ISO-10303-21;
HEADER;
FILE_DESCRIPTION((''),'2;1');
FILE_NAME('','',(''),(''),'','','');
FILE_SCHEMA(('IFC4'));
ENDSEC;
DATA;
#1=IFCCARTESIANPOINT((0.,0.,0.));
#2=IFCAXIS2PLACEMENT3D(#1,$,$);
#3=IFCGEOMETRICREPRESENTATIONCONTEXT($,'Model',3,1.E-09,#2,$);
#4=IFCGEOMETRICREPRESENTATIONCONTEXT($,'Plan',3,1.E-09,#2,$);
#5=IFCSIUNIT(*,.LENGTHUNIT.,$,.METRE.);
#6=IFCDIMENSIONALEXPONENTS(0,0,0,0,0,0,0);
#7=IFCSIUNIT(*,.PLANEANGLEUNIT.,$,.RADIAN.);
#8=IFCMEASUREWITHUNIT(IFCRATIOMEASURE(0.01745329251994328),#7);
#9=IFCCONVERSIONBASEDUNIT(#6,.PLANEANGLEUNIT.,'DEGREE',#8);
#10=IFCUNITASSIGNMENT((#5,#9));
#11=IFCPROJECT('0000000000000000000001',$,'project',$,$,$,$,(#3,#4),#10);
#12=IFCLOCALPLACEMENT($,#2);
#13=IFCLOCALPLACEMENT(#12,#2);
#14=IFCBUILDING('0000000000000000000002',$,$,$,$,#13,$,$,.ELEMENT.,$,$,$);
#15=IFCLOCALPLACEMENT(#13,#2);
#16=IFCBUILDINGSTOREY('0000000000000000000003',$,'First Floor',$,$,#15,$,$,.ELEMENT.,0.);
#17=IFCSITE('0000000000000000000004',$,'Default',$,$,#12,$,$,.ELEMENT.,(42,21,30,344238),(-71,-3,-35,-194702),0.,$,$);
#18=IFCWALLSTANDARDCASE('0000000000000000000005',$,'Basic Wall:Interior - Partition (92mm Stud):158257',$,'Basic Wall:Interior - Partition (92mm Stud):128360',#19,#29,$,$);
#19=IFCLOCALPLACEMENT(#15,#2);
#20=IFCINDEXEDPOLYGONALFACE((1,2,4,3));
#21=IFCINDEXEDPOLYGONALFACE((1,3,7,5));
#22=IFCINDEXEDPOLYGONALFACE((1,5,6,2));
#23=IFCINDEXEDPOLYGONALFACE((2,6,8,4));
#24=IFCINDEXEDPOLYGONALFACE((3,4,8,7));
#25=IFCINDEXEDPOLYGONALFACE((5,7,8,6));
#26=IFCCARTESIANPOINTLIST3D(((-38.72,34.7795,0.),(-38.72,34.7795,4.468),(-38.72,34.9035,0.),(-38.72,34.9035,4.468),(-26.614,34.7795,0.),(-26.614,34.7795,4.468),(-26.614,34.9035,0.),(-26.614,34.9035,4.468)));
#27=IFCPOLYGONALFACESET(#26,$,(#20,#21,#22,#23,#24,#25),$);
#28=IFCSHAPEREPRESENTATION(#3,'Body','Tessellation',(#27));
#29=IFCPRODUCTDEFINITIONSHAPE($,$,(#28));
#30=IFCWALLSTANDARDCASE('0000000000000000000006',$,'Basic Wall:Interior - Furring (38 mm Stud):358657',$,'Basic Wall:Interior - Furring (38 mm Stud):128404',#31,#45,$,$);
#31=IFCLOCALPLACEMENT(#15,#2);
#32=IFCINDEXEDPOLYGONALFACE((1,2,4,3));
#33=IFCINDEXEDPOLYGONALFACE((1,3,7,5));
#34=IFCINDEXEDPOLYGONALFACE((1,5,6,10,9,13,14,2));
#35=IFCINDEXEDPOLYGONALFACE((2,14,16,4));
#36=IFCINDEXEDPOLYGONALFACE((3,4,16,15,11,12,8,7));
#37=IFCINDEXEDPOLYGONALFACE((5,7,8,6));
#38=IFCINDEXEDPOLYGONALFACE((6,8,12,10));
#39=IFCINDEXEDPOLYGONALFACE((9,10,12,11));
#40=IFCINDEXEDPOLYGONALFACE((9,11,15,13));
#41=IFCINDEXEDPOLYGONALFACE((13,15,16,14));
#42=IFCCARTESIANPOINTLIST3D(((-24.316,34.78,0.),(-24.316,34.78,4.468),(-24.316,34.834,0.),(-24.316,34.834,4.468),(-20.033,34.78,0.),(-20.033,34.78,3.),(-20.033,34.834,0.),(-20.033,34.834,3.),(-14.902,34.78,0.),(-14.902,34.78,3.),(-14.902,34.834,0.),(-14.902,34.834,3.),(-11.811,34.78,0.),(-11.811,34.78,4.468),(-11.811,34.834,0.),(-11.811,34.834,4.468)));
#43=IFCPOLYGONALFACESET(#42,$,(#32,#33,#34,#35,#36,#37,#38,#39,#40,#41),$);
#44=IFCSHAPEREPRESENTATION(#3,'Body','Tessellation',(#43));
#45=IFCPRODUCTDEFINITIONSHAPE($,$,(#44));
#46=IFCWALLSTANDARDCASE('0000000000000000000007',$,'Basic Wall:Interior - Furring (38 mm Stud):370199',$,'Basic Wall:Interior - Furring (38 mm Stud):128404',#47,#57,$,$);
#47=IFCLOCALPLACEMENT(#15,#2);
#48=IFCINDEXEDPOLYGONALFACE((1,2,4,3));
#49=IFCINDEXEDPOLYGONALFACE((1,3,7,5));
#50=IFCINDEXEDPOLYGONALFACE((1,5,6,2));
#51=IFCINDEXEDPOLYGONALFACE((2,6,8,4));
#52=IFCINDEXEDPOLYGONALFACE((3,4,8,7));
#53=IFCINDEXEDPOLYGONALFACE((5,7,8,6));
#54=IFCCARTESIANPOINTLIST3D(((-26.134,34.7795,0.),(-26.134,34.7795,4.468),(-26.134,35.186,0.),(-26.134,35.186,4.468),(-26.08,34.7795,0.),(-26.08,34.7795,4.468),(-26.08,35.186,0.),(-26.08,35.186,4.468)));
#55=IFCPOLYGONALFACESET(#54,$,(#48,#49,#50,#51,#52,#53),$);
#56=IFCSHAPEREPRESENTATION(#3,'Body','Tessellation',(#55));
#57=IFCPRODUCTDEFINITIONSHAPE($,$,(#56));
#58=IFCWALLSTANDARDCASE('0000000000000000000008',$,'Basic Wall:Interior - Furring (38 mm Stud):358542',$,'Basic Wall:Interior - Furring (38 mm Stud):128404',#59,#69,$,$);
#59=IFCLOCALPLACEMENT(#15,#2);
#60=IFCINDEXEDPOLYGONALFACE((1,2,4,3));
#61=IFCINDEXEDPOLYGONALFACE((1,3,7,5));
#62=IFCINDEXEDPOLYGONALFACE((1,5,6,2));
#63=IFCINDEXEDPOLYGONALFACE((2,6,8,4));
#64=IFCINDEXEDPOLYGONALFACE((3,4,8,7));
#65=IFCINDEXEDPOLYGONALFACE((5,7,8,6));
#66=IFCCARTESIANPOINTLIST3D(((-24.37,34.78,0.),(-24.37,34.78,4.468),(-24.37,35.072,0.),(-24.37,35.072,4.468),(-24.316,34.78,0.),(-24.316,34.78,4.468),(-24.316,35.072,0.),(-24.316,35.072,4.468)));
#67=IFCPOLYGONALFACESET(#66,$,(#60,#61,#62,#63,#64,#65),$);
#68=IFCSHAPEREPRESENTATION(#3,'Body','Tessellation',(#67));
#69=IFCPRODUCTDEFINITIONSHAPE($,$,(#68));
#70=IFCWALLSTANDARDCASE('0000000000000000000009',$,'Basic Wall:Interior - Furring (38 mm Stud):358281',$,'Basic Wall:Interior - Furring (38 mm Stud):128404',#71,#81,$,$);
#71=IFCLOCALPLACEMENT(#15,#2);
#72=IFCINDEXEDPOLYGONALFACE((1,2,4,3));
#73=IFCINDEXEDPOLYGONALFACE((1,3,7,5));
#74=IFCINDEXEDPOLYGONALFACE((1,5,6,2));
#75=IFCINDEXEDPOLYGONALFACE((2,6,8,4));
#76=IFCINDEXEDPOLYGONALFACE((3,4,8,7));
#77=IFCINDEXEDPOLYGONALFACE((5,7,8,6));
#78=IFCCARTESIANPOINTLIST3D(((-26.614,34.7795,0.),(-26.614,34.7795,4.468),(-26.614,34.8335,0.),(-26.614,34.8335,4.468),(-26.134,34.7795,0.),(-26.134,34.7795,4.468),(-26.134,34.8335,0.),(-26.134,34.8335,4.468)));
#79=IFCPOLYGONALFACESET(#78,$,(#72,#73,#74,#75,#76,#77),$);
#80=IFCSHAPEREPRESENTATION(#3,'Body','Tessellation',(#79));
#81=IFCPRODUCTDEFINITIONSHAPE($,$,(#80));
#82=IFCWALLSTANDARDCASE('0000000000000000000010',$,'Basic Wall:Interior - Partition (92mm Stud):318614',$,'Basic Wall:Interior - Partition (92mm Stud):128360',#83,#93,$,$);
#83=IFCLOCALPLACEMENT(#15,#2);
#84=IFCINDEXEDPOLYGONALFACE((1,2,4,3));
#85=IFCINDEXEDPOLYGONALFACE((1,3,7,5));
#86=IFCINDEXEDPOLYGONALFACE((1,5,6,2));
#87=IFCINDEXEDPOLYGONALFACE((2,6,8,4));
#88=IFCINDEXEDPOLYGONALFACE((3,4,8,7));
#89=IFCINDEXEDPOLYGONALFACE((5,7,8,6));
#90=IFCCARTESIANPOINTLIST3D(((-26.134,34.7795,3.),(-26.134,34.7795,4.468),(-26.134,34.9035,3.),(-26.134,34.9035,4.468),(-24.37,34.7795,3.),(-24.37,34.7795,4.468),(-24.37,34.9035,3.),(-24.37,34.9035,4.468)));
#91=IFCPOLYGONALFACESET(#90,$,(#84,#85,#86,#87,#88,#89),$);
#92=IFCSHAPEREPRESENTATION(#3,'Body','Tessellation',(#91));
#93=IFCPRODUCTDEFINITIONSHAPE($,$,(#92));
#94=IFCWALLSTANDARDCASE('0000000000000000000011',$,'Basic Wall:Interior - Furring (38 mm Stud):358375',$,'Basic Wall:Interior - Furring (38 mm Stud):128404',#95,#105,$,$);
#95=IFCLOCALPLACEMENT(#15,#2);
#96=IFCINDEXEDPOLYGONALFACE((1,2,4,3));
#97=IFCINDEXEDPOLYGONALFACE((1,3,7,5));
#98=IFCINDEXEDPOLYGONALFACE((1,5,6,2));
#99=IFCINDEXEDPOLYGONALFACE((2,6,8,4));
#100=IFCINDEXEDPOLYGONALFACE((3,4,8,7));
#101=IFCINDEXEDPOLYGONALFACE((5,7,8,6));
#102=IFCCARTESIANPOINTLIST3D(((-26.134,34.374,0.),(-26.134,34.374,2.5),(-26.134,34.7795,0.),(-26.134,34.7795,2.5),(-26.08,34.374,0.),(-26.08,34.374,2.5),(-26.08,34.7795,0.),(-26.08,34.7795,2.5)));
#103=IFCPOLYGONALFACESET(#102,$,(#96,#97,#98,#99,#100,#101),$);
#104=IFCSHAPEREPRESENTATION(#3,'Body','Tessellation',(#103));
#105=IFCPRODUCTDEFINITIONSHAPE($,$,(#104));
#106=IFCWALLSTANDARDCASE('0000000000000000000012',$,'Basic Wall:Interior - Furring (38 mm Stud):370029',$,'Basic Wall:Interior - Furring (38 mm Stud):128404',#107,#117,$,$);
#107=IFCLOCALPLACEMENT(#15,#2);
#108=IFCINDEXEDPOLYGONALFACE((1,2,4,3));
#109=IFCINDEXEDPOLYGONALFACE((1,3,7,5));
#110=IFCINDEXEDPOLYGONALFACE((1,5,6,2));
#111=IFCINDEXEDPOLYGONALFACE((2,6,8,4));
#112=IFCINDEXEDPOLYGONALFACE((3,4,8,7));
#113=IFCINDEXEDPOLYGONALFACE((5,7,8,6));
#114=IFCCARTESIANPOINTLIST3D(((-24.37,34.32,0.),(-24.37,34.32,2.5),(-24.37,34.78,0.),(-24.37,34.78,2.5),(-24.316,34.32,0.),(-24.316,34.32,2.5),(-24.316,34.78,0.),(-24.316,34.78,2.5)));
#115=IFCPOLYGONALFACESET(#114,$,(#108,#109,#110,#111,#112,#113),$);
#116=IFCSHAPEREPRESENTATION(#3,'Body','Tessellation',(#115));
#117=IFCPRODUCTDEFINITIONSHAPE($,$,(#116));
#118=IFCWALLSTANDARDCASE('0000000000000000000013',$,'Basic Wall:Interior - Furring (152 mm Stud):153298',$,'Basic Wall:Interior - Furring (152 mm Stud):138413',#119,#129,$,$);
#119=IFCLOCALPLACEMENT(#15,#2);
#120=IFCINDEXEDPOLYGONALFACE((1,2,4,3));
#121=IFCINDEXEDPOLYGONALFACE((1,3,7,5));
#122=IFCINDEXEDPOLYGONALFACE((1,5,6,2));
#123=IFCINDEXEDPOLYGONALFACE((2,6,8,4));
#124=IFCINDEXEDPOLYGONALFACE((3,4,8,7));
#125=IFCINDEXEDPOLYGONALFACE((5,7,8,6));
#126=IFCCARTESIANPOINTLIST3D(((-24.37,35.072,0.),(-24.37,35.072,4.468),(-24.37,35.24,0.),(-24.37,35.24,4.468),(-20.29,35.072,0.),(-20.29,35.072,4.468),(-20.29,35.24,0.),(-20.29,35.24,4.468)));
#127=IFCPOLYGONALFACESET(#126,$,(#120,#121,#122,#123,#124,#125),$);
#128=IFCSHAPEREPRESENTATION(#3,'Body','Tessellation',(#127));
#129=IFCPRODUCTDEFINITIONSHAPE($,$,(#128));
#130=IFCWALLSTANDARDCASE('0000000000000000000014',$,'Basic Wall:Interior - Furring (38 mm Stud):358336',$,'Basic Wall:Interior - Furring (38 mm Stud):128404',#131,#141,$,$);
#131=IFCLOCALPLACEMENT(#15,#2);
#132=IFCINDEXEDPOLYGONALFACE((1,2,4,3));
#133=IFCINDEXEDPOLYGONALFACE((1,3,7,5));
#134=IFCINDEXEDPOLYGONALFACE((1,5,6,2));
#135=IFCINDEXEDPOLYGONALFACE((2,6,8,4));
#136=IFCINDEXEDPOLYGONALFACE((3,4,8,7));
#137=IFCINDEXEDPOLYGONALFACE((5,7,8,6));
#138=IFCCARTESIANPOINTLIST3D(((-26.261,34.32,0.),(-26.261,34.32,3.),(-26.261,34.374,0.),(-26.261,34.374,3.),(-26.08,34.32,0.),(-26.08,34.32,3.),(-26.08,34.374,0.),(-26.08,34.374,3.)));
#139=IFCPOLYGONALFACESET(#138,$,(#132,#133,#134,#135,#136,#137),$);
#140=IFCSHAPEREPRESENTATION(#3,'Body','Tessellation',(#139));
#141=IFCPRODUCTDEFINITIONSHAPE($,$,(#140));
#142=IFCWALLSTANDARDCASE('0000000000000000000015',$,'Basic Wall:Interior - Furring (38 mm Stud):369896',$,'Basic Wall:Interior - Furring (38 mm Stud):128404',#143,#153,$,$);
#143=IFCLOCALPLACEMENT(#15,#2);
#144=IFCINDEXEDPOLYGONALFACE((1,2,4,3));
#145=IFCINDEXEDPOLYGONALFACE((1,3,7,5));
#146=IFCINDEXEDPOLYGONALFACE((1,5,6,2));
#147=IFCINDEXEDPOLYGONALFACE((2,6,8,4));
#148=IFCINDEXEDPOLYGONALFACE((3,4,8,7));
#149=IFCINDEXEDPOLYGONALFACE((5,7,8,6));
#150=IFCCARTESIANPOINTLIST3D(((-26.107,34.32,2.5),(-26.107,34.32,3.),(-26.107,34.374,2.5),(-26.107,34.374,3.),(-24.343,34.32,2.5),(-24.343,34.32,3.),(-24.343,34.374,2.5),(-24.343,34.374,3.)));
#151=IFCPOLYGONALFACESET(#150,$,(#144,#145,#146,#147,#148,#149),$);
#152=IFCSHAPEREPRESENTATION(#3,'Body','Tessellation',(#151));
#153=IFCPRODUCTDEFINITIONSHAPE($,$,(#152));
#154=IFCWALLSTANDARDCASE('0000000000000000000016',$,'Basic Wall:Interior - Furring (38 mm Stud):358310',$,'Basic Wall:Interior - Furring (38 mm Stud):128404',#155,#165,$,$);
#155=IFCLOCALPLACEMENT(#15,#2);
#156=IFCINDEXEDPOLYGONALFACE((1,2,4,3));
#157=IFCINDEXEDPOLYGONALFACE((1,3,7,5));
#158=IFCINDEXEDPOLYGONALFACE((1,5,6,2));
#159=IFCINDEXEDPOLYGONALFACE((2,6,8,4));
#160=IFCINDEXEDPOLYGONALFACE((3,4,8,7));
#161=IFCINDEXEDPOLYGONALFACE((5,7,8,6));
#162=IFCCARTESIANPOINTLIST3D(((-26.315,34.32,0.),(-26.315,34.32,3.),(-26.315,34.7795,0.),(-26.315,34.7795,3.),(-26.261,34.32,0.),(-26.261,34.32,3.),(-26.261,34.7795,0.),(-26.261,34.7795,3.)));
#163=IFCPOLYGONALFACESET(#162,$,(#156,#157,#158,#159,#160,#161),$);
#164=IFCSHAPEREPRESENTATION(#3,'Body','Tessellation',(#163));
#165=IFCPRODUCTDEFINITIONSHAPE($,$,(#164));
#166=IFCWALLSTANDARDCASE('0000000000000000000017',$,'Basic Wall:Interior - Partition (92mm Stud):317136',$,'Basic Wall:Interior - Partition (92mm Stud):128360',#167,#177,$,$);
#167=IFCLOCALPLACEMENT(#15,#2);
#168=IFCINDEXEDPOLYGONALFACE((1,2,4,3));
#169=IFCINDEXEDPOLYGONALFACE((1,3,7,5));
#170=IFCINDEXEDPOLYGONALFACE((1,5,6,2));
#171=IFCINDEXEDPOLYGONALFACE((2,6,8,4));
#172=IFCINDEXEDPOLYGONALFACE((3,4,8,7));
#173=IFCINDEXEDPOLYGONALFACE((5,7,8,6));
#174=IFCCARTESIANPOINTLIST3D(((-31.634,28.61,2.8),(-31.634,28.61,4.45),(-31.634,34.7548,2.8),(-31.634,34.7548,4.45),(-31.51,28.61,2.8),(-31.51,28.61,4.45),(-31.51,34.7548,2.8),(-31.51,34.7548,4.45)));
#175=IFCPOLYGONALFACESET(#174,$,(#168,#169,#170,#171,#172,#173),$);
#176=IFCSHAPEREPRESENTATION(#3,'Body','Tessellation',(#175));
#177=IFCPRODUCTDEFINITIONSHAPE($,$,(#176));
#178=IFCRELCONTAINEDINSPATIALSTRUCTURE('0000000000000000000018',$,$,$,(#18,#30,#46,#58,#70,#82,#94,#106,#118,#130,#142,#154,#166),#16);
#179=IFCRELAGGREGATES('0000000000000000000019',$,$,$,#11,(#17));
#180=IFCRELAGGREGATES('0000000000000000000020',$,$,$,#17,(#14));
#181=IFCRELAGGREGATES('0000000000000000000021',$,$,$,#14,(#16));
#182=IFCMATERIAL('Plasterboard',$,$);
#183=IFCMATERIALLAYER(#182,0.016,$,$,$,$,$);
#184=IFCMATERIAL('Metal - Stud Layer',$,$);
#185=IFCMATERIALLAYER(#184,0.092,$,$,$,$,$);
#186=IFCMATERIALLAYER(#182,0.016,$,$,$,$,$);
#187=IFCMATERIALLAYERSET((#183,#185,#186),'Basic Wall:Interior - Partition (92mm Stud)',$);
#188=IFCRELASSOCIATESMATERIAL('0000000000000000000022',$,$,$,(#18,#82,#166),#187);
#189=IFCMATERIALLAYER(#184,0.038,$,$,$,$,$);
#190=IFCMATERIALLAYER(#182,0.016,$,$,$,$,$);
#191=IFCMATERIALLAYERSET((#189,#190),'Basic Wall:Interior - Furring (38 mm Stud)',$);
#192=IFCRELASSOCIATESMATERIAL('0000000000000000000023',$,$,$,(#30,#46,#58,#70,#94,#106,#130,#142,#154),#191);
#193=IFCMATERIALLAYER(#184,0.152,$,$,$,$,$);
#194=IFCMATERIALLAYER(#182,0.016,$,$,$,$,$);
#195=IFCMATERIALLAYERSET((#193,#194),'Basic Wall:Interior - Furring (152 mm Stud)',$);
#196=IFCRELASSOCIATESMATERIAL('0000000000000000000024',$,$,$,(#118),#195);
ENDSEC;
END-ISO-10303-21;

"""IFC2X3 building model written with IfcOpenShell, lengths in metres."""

from ifc_helpers import new_model, entity, si_unit, converted_unit, frame, frame_2d, origin, place, context, project, spatial, rectangle, extrude, material, layer, layer_set, layer_usage, element, save


model = new_model("IFC2X3")

# Units and contexts
model_context = context("Model", 3, precision=1e-09, world=origin())
plan_context = context("Plan", 3, precision=1e-09, world=origin())
ifc_project = project(units=[si_unit("LENGTHUNIT", "METRE"), converted_unit("PLANEANGLEUNIT", "DEGREE", entity("IfcRatioMeasure", 0.01745329251994328), si_unit("PLANEANGLEUNIT", "RADIAN"), dimensions=[0, 0, 0, 0, 0, 0, 0])], contexts=[model_context, plan_context])

# Site, building, storey
site_placement = place(None, origin())
site = spatial("IfcSite", under=ifc_project, at=site_placement, Name="Default", CompositionType="ELEMENT", RefLatitude=(42, 21, 30, 344238), RefLongitude=(-71, -3, -35, -194702), RefElevation=0.0)
building_placement = place(site_placement, origin())
building = spatial("IfcBuilding", under=site, at=building_placement, CompositionType="ELEMENT")
storey_placement = place(building_placement, origin())
storey = spatial("IfcBuildingStorey", under=building, at=storey_placement, Name="First Floor", CompositionType="ELEMENT", Elevation=0.0)

# Wall
ifc_material_1 = material(Name="Plasterboard")
ifc_layer_1 = layer(ifc_material_1, 0.016)
ifc_material_2 = material(Name="Metal - Stud Layer")
ifc_layer_2 = layer(ifc_material_2, 0.092)
ifc_layer_3 = layer(ifc_material_1, 0.016)
ifc_layer_set_1 = layer_set([ifc_layer_1, ifc_layer_2, ifc_layer_3], Name="Basic Wall:Interior - Partition (92mm Stud)")
ifc_layer_usage_1 = layer_usage(ifc_layer_set_1, "AXIS2", "NEGATIVE", 0.062)
wall_1_placement = place(storey_placement, frame((-26.614, 34.8415, 0.0), z_axis=(0.0, 0.0, 1.0), x_axis=(-1.0, 0.0, 0.0)))
element("IfcWallStandardCase", 1, at=wall_1_placement, inside=storey, material=ifc_layer_usage_1, Name="Basic Wall:Interior - Partition (92mm Stud):158257", ObjectType="Basic Wall:Interior - Partition (92mm Stud):128360", context=model_context, shape_type="SweptSolid", body=[
    extrude(rectangle(XDim=12.106, YDim=0.124, at=frame_2d((6.053, 0.0), x_axis=(-1.0, 0.0))), origin(), (0.0, 0.0, 1.0), 4.468),
])

# Wall, opening
ifc_layer_4 = layer(ifc_material_2, 0.038)
ifc_layer_5 = layer(ifc_material_1, 0.016)
ifc_layer_set_2 = layer_set([ifc_layer_4, ifc_layer_5], Name="Basic Wall:Interior - Furring (38 mm Stud)")
ifc_layer_usage_2 = layer_usage(ifc_layer_set_2, "AXIS2", "NEGATIVE", 0.027)
wall_2_placement = place(storey_placement, frame((-24.316, 34.807, 0.0)))
wall_2 = element("IfcWallStandardCase", 2, at=wall_2_placement, inside=storey, material=ifc_layer_usage_2, Name="Basic Wall:Interior - Furring (38 mm Stud):358657", ObjectType="Basic Wall:Interior - Furring (38 mm Stud):128404", context=model_context, shape_type="SweptSolid", body=[
    extrude(rectangle(XDim=12.505, YDim=0.054, at=frame_2d((6.2525, 0.0), x_axis=(-1.0, 0.0))), origin(), (0.0, 0.0, 1.0), 4.468),
])
opening_placement = place(wall_2_placement, frame((6.8485, 0.027, 1.5)))
element("IfcOpeningElement", 3, at=opening_placement, cuts=wall_2, ObjectType="Opening", context=model_context, shape_type="SweptSolid", body=[
    extrude(rectangle(XDim=3.0, YDim=5.131, at=frame_2d((0.0, 0.0), x_axis=(0.0, 1.0))), frame((0.0, 0.0, 0.0), z_axis=(0.0, -1.0, 0.0), x_axis=(1.0, 0.0, 0.0)), (0.0, 0.0, 1.0), 0.054),
])

# Walls
wall_3_placement = place(storey_placement, frame((-26.107, 34.7795, 0.0), z_axis=(0.0, 0.0, 1.0), x_axis=(0.0, 1.0, 0.0)))
element("IfcWallStandardCase", 4, at=wall_3_placement, inside=storey, material=ifc_layer_usage_2, Name="Basic Wall:Interior - Furring (38 mm Stud):370199", ObjectType="Basic Wall:Interior - Furring (38 mm Stud):128404", context=model_context, shape_type="SweptSolid", body=[
    extrude(rectangle(XDim=0.4065, YDim=0.054, at=frame_2d((0.2032, 0.0), x_axis=(-1.0, 0.0))), origin(), (0.0, 0.0, 1.0), 4.468),
])
wall_4_placement = place(storey_placement, frame((-24.343, 35.072, 0.0), z_axis=(0.0, 0.0, 1.0), x_axis=(0.0, -1.0, 0.0)))
element("IfcWallStandardCase", 5, at=wall_4_placement, inside=storey, material=ifc_layer_usage_2, Name="Basic Wall:Interior - Furring (38 mm Stud):358542", ObjectType="Basic Wall:Interior - Furring (38 mm Stud):128404", context=model_context, shape_type="SweptSolid", body=[
    extrude(rectangle(XDim=0.292, YDim=0.054, at=frame_2d((0.146, 0.0), x_axis=(-1.0, 0.0))), origin(), (0.0, 0.0, 1.0), 4.468),
])
wall_5_placement = place(storey_placement, frame((-26.614, 34.8065, 0.0)))
element("IfcWallStandardCase", 6, at=wall_5_placement, inside=storey, material=ifc_layer_usage_2, Name="Basic Wall:Interior - Furring (38 mm Stud):358281", ObjectType="Basic Wall:Interior - Furring (38 mm Stud):128404", context=model_context, shape_type="SweptSolid", body=[
    extrude(rectangle(XDim=0.48, YDim=0.054, at=frame_2d((0.24, 0.0), x_axis=(-1.0, 0.0))), origin(), (0.0, 0.0, 1.0), 4.468),
])
wall_6_placement = place(storey_placement, frame((-24.37, 34.8415, 3.0), z_axis=(0.0, 0.0, 1.0), x_axis=(-1.0, 0.0, 0.0)))
element("IfcWallStandardCase", 7, at=wall_6_placement, inside=storey, material=ifc_layer_usage_1, Name="Basic Wall:Interior - Partition (92mm Stud):318614", ObjectType="Basic Wall:Interior - Partition (92mm Stud):128360", context=model_context, shape_type="SweptSolid", body=[
    extrude(rectangle(XDim=1.764, YDim=0.124, at=frame_2d((0.882, 0.0), x_axis=(-1.0, 0.0))), origin(), (0.0, 0.0, 1.0), 1.468),
])
wall_7_placement = place(storey_placement, frame((-26.107, 34.374, 0.0), z_axis=(0.0, 0.0, 1.0), x_axis=(0.0, 1.0, 0.0)))
element("IfcWallStandardCase", 8, at=wall_7_placement, inside=storey, material=ifc_layer_usage_2, Name="Basic Wall:Interior - Furring (38 mm Stud):358375", ObjectType="Basic Wall:Interior - Furring (38 mm Stud):128404", context=model_context, shape_type="SweptSolid", body=[
    extrude(rectangle(XDim=0.4055, YDim=0.054, at=frame_2d((0.2028, 0.0), x_axis=(-1.0, 0.0))), origin(), (0.0, 0.0, 1.0), 2.5),
])
wall_8_placement = place(storey_placement, frame((-24.343, 34.78, 0.0), z_axis=(0.0, 0.0, 1.0), x_axis=(0.0, -1.0, 0.0)))
element("IfcWallStandardCase", 9, at=wall_8_placement, inside=storey, material=ifc_layer_usage_2, Name="Basic Wall:Interior - Furring (38 mm Stud):370029", ObjectType="Basic Wall:Interior - Furring (38 mm Stud):128404", context=model_context, shape_type="SweptSolid", body=[
    extrude(rectangle(XDim=0.46, YDim=0.054, at=frame_2d((0.23, 0.0), x_axis=(-1.0, 0.0))), origin(), (0.0, 0.0, 1.0), 2.5),
])
ifc_layer_6 = layer(ifc_material_2, 0.152)
ifc_layer_7 = layer(ifc_material_1, 0.016)
ifc_layer_set_3 = layer_set([ifc_layer_6, ifc_layer_7], Name="Basic Wall:Interior - Furring (152 mm Stud)")
ifc_layer_usage_3 = layer_usage(ifc_layer_set_3, "AXIS2", "POSITIVE", -0.084)
wall_9_placement = place(storey_placement, frame((-24.37, 35.156, 0.0)))
element("IfcWallStandardCase", 10, at=wall_9_placement, inside=storey, material=ifc_layer_usage_3, Name="Basic Wall:Interior - Furring (152 mm Stud):153298", ObjectType="Basic Wall:Interior - Furring (152 mm Stud):138413", context=model_context, shape_type="SweptSolid", body=[
    extrude(rectangle(XDim=4.08, YDim=0.168, at=frame_2d((2.04, 0.0), x_axis=(-1.0, 0.0))), origin(), (0.0, 0.0, 1.0), 4.468),
])
wall_10_placement = place(storey_placement, frame((-26.261, 34.347, 0.0)))
element("IfcWallStandardCase", 11, at=wall_10_placement, inside=storey, material=ifc_layer_usage_2, Name="Basic Wall:Interior - Furring (38 mm Stud):358336", ObjectType="Basic Wall:Interior - Furring (38 mm Stud):128404", context=model_context, shape_type="SweptSolid", body=[
    extrude(rectangle(XDim=0.181, YDim=0.054, at=frame_2d((0.0905, 0.0), x_axis=(-1.0, 0.0))), origin(), (0.0, 0.0, 1.0), 3.0),
])
wall_11_placement = place(storey_placement, frame((-26.107, 34.347, 2.5)))
element("IfcWallStandardCase", 12, at=wall_11_placement, inside=storey, material=ifc_layer_usage_2, Name="Basic Wall:Interior - Furring (38 mm Stud):369896", ObjectType="Basic Wall:Interior - Furring (38 mm Stud):128404", context=model_context, shape_type="SweptSolid", body=[
    extrude(rectangle(XDim=1.764, YDim=0.054, at=frame_2d((0.882, 0.0), x_axis=(-1.0, 0.0))), origin(), (0.0, 0.0, 1.0), 0.5),
])
wall_12_placement = place(storey_placement, frame((-26.288, 34.7795, 0.0), z_axis=(0.0, 0.0, 1.0), x_axis=(0.0, -1.0, 0.0)))
element("IfcWallStandardCase", 13, at=wall_12_placement, inside=storey, material=ifc_layer_usage_2, Name="Basic Wall:Interior - Furring (38 mm Stud):358310", ObjectType="Basic Wall:Interior - Furring (38 mm Stud):128404", context=model_context, shape_type="SweptSolid", body=[
    extrude(rectangle(XDim=0.4595, YDim=0.054, at=frame_2d((0.2298, 0.0), x_axis=(-1.0, 0.0))), origin(), (0.0, 0.0, 1.0), 3.0),
])
wall_13_placement = place(storey_placement, frame((-31.572, 34.7548, 2.8), z_axis=(0.0, 0.0, 1.0), x_axis=(0.0, -1.0, 0.0)))
element("IfcWallStandardCase", 14, at=wall_13_placement, inside=storey, material=ifc_layer_usage_1, Name="Basic Wall:Interior - Partition (92mm Stud):317136", ObjectType="Basic Wall:Interior - Partition (92mm Stud):128360", context=model_context, shape_type="SweptSolid", body=[
    extrude(rectangle(XDim=6.1448, YDim=0.124, at=frame_2d((3.0724, 0.0), x_axis=(-1.0, 0.0))), origin(), (0.0, 0.0, 1.0), 1.65),
])

save(model, "model.ifc")
